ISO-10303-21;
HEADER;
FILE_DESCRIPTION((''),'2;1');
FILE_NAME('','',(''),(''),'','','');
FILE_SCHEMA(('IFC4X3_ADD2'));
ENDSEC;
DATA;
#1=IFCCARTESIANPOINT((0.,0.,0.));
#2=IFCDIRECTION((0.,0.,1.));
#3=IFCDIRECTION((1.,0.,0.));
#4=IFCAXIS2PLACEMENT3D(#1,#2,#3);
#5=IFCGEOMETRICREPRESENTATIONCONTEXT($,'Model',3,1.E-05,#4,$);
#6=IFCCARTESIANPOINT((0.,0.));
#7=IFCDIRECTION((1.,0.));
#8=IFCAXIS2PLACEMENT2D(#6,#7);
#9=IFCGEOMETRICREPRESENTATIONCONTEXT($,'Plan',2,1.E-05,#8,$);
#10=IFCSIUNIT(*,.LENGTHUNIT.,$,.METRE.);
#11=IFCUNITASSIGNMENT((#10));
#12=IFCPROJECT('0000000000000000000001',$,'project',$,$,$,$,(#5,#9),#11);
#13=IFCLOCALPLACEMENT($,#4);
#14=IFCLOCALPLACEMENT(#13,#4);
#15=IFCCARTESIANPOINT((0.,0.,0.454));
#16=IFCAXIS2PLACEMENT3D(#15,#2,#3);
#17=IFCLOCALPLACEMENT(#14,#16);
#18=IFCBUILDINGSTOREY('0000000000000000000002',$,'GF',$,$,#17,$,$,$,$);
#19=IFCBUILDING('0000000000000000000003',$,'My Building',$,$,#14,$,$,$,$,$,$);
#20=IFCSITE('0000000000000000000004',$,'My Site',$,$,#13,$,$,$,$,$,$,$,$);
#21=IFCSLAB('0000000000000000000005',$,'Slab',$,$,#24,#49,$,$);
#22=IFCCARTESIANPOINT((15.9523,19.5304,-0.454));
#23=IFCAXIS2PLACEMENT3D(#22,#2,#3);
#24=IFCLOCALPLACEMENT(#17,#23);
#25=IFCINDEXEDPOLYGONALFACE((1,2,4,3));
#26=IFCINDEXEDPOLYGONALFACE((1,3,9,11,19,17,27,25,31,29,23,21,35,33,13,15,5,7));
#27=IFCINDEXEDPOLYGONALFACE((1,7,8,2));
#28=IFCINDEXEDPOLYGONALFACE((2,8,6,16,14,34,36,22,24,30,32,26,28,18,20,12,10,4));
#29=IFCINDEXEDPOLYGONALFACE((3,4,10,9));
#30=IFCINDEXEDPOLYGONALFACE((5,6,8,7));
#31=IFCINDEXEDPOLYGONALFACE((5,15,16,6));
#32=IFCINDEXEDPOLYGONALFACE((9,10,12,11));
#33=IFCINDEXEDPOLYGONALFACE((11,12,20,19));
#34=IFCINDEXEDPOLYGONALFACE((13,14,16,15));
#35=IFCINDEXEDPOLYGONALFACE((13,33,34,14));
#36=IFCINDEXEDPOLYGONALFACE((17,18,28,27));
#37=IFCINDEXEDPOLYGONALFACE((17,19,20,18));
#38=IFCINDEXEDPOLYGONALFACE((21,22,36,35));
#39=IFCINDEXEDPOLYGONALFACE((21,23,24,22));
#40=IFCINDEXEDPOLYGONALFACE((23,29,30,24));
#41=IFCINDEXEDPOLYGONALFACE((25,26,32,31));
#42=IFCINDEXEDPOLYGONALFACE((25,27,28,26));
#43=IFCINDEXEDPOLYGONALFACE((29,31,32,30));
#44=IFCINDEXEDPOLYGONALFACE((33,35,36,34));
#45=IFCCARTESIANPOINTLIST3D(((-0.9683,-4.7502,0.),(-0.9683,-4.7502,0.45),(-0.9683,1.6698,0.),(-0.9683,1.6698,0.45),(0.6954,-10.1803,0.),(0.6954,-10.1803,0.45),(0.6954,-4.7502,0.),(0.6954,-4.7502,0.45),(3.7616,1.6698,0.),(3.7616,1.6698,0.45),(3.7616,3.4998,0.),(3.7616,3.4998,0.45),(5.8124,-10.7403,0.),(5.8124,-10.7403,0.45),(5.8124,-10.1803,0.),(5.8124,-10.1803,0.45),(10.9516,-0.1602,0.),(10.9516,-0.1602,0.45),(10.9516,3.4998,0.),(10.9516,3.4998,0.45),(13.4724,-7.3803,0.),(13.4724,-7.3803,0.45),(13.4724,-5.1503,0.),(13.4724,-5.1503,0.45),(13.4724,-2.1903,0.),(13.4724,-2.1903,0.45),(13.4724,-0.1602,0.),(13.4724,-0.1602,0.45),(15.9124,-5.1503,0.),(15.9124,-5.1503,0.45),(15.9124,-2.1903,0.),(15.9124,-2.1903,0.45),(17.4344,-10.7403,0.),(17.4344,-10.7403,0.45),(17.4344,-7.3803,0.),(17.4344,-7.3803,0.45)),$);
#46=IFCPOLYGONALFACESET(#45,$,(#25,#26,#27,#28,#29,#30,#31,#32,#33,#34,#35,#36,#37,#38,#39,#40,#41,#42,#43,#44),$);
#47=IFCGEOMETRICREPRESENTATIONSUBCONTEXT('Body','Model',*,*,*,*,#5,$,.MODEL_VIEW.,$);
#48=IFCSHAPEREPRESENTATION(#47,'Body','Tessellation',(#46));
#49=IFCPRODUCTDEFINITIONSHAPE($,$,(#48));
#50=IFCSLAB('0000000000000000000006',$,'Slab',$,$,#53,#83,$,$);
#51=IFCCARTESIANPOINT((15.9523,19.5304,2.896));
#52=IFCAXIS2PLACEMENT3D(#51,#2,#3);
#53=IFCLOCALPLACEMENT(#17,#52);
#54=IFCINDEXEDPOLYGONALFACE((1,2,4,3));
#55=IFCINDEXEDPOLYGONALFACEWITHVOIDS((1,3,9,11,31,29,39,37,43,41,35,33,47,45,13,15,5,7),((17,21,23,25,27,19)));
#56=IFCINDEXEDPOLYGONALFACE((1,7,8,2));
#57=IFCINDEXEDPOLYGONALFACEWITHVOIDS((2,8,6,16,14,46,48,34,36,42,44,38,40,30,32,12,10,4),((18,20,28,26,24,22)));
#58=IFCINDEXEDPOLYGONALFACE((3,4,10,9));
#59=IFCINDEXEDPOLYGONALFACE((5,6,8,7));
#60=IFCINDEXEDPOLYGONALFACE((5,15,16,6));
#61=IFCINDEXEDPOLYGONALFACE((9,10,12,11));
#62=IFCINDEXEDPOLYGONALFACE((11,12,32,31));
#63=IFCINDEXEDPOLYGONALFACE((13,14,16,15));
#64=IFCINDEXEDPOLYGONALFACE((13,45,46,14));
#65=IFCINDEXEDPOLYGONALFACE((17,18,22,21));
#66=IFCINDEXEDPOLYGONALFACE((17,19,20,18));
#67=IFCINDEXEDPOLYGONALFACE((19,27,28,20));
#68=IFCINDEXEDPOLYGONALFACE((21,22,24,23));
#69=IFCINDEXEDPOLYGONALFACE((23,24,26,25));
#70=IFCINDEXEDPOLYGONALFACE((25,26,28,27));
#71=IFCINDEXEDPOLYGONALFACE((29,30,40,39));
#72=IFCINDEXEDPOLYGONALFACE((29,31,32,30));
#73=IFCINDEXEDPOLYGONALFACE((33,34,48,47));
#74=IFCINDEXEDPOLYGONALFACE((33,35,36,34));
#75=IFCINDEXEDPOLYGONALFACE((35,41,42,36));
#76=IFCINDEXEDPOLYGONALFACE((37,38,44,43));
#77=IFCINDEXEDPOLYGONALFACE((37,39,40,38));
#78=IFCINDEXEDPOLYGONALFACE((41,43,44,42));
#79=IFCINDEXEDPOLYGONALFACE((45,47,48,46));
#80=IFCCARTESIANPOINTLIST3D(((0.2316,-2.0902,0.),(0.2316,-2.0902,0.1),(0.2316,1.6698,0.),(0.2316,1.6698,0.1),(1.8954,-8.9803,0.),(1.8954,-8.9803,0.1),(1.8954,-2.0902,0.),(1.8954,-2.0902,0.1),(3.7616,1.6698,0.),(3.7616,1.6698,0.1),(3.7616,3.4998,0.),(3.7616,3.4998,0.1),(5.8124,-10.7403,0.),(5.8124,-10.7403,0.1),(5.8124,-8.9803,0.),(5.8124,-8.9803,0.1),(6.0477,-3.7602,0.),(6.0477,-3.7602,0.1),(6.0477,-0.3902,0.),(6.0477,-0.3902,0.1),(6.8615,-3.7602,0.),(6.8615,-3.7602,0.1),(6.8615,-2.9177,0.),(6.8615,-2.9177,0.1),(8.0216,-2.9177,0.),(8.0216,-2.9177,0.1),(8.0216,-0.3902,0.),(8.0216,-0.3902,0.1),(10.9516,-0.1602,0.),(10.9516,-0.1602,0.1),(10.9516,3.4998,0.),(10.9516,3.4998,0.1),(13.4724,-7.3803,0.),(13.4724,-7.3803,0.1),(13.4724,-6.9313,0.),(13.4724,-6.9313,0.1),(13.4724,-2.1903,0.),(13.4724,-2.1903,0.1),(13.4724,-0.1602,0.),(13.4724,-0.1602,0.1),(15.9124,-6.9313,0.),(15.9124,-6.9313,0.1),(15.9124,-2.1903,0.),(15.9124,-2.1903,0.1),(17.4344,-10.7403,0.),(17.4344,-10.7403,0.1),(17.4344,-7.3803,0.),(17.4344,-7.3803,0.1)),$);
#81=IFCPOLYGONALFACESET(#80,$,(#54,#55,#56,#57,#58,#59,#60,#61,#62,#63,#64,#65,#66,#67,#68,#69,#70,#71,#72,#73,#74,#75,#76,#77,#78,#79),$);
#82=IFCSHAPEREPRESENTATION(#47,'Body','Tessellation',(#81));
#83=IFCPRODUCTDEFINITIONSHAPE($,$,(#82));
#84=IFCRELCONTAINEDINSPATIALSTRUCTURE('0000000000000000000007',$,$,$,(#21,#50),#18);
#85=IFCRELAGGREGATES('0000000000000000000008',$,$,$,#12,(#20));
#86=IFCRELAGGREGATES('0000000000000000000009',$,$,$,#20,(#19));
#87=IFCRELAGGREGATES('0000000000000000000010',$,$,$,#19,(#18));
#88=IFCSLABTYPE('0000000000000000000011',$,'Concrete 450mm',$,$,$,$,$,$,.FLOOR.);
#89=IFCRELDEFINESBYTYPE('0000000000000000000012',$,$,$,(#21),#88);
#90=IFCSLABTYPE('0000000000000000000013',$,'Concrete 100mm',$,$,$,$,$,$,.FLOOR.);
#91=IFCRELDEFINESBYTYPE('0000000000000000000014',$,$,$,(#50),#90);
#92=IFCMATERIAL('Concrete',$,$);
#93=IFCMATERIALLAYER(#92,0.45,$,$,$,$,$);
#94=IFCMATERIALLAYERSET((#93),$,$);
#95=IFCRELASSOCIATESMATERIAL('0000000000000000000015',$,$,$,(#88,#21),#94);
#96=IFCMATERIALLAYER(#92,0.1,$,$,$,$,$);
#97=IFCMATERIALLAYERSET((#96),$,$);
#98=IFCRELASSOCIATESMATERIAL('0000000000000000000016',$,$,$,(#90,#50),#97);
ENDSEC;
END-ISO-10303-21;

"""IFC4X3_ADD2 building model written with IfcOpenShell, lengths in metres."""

from ifc_helpers import new_model, si_unit, frame, origin_with_axes, origin_2d_with_axis, place, context, subcontext, project, spatial, line, indexed_curve, outline, extrude, material, layer, layer_set, layer_usage, type_object, element, save


model = new_model("IFC4X3_ADD2")

# Units and contexts
model_context = context("Model", 3, precision=1e-05, world=origin_with_axes())
plan_context = context("Plan", 2, precision=1e-05, world=origin_2d_with_axis())
body_context = subcontext(model_context, "Body", "Model", "MODEL_VIEW")
ifc_project = project(units=[si_unit("LENGTHUNIT", "METRE")], contexts=[model_context, plan_context])

# Site, building, storey
site_placement = place(None, origin_with_axes())
site = spatial("IfcSite", under=ifc_project, at=site_placement, Name="My Site")
building_placement = place(site_placement, origin_with_axes())
building = spatial("IfcBuilding", under=site, at=building_placement, Name="My Building")
storey_placement = place(building_placement, frame((0.0, 0.0, 0.454), z_axis=(0.0, 0.0, 1.0), x_axis=(1.0, 0.0, 0.0)))
storey = spatial("IfcBuildingStorey", under=building, at=storey_placement, Name="GF")

# Slabs
ifc_material_1 = material(Name="Concrete")
ifc_layer_1 = layer(ifc_material_1, 0.45)
ifc_layer_set_1 = layer_set([ifc_layer_1])
ifc_layer_usage_1 = layer_usage(ifc_layer_set_1, "AXIS3", "POSITIVE", 0.0)
slab_type_1 = type_object("IfcSlabType", Name="Concrete 450mm", PredefinedType="FLOOR", material=ifc_layer_set_1)
slab_1_placement = place(storey_placement, frame((15.9523, 19.5304, -0.454), z_axis=(0.0, 0.0, 1.0), x_axis=(1.0, 0.0, 0.0)))
element("IfcSlab", 1, at=slab_1_placement, inside=storey, type_object=slab_type_1, material=ifc_layer_usage_1, Name="Slab", context=body_context, shape_type="SweptSolid", body=[
    extrude(outline(indexed_curve([(0.6954, -4.7502), (-0.9683, -4.7502), (-0.9683, 1.6698), (3.7616, 1.6698), (3.7616, 3.4998), (10.9516, 3.4998), (10.9516, -0.1602), (13.4724, -0.1602), (13.4724, -2.1903), (15.9124, -2.1903), (15.9124, -5.1503), (13.4724, -5.1503), (13.4724, -7.3803), (17.4344, -7.3803), (17.4344, -10.7403), (5.8124, -10.7403), (5.8124, -10.1803), (0.6954, -10.1803)], segments=[line(5, 4), line(4, 3), line(3, 2), line(2, 1), line(1, 18), line(18, 17), line(17, 16), line(16, 15), line(15, 14), line(14, 13), line(13, 12), line(12, 11), line(11, 10), line(10, 9), line(9, 8), line(8, 7), line(7, 6), line(6, 5)], self_intersect=False)), None, (0.0, 0.0, 1.0), 0.45),
])
ifc_layer_2 = layer(ifc_material_1, 0.1)
ifc_layer_set_2 = layer_set([ifc_layer_2])
ifc_layer_usage_2 = layer_usage(ifc_layer_set_2, "AXIS3", "POSITIVE", 0.0)
slab_type_2 = type_object("IfcSlabType", Name="Concrete 100mm", PredefinedType="FLOOR", material=ifc_layer_set_2)
slab_2_placement = place(storey_placement, frame((15.9523, 19.5304, 2.896), z_axis=(0.0, 0.0, 1.0), x_axis=(1.0, 0.0, 0.0)))
element("IfcSlab", 2, at=slab_2_placement, inside=storey, type_object=slab_type_2, material=ifc_layer_usage_2, Name="Slab", context=body_context, shape_type="SweptSolid", body=[
    extrude(outline(indexed_curve([(5.8124, -8.9803), (5.8124, -10.7403), (17.4344, -10.7403), (17.4344, -7.3803), (13.4724, -7.3803), (13.4724, -6.9313), (15.9124, -6.9313), (15.9124, -2.1903), (13.4724, -2.1903), (13.4724, -0.1602), (10.9516, -0.1602), (10.9516, 3.4998), (3.7616, 3.4998), (3.7616, 1.6698), (0.2316, 1.6698), (0.2316, -2.0902), (1.8954, -2.0902), (1.8954, -8.9803), (8.0216, -2.9177), (8.0216, -0.3902), (6.0477, -0.3902), (6.0477, -3.7602), (6.8615, -3.7602), (6.8615, -2.9177)], segments=[line(8, 7), line(7, 6), line(6, 5), line(5, 4), line(4, 3), line(3, 2), line(2, 1), line(1, 18), line(18, 17), line(17, 16), line(16, 15), line(15, 14), line(14, 13), line(13, 12), line(12, 11), line(11, 10), line(10, 9), line(9, 8)], self_intersect=False), holes=[indexed_curve([(5.8124, -8.9803), (5.8124, -10.7403), (17.4344, -10.7403), (17.4344, -7.3803), (13.4724, -7.3803), (13.4724, -6.9313), (15.9124, -6.9313), (15.9124, -2.1903), (13.4724, -2.1903), (13.4724, -0.1602), (10.9516, -0.1602), (10.9516, 3.4998), (3.7616, 3.4998), (3.7616, 1.6698), (0.2316, 1.6698), (0.2316, -2.0902), (1.8954, -2.0902), (1.8954, -8.9803), (8.0216, -2.9177), (8.0216, -0.3902), (6.0477, -0.3902), (6.0477, -3.7602), (6.8615, -3.7602), (6.8615, -2.9177)], segments=[line(24, 23), line(23, 22), line(22, 21), line(21, 20), line(20, 19), line(19, 24)], self_intersect=False)]), None, (0.0, 0.0, 1.0), 0.1),
])

save(model, "model.ifc")
